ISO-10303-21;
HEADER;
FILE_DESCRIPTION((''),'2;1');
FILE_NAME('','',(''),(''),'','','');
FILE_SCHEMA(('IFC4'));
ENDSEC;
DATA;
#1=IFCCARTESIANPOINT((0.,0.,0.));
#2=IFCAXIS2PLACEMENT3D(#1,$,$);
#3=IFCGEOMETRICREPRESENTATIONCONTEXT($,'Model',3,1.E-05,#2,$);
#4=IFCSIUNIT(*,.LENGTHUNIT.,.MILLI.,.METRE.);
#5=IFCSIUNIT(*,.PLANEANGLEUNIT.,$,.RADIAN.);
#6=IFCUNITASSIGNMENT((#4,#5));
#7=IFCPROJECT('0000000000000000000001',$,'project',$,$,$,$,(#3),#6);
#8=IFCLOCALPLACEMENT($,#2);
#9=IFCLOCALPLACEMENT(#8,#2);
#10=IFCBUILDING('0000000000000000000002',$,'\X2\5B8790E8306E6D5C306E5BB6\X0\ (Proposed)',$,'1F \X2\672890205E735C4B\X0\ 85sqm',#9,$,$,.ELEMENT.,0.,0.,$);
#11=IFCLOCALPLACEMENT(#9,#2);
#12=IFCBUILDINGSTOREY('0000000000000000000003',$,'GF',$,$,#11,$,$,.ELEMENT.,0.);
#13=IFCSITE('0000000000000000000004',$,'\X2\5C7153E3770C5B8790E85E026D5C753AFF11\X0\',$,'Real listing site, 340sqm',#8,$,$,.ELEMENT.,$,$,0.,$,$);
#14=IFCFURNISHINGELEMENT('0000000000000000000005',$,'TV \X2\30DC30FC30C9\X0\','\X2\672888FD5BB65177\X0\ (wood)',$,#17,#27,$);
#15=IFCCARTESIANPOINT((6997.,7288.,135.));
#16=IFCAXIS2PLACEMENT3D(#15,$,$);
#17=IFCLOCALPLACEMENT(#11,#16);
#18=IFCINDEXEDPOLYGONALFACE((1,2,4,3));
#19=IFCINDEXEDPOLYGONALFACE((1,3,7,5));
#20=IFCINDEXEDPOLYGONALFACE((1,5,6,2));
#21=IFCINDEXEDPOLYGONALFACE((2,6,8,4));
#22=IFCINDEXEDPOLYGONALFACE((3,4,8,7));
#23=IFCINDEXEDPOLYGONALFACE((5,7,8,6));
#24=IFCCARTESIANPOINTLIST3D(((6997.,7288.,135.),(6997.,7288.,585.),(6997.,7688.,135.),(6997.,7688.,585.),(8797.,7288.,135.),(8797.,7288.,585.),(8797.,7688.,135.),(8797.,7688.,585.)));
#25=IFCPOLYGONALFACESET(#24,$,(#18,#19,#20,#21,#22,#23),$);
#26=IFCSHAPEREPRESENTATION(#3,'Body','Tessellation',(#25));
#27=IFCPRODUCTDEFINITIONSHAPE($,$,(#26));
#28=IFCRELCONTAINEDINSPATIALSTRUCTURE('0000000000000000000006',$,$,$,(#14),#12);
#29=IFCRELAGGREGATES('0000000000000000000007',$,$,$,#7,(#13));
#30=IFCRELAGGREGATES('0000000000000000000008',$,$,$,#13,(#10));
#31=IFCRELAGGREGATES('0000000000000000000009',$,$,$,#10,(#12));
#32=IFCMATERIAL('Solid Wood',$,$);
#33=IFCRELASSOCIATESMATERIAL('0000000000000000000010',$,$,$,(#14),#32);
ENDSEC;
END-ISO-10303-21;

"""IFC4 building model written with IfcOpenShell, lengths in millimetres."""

from ifc_helpers import new_model, si_unit, frame, frame_2d, origin, place, context, project, spatial, rectangle, extrude, material, element, save


model = new_model("IFC4")

# Units and contexts
model_context = context("Model", 3, precision=1e-05, world=origin())
ifc_project = project(units=[si_unit("LENGTHUNIT", "METRE", prefix="MILLI"), si_unit("PLANEANGLEUNIT", "RADIAN")], contexts=[model_context])

# Site, building, storey
site_placement = place(None, origin())
site = spatial("IfcSite", under=ifc_project, at=site_placement, Name="山口県宇部市浜町１", ObjectType="Real listing site, 340sqm", CompositionType="ELEMENT", RefElevation=0.0)
building_placement = place(site_placement, origin())
building = spatial("IfcBuilding", under=site, at=building_placement, Name="宇部の浜の家 (Proposed)", ObjectType="1F 木造平屋 85sqm", CompositionType="ELEMENT", ElevationOfRefHeight=0.0, ElevationOfTerrain=0.0)
storey_placement = place(building_placement, origin())
storey = spatial("IfcBuildingStorey", under=building, at=storey_placement, Name="GF", CompositionType="ELEMENT", Elevation=0.0)

# Shared definitions
ifc_material_1 = material(Name="Solid Wood")

# Furnishing element
furnishing_1_placement = place(storey_placement, frame((6997.0, 7288.0, 135.0)))
element("IfcFurnishingElement", 1, at=furnishing_1_placement, inside=storey, material=ifc_material_1, Name="TV ボード", Description="木製家具 (wood)", context=model_context, shape_type="SweptSolid", body=[
    extrude(rectangle(XDim=1800.0, YDim=400.0, at=frame_2d((900.0, 200.0))), frame((6997.0, 7288.0, 135.0)), (0.0, 0.0, 1.0), 450.0),
])

save(model, "model.ifc")
